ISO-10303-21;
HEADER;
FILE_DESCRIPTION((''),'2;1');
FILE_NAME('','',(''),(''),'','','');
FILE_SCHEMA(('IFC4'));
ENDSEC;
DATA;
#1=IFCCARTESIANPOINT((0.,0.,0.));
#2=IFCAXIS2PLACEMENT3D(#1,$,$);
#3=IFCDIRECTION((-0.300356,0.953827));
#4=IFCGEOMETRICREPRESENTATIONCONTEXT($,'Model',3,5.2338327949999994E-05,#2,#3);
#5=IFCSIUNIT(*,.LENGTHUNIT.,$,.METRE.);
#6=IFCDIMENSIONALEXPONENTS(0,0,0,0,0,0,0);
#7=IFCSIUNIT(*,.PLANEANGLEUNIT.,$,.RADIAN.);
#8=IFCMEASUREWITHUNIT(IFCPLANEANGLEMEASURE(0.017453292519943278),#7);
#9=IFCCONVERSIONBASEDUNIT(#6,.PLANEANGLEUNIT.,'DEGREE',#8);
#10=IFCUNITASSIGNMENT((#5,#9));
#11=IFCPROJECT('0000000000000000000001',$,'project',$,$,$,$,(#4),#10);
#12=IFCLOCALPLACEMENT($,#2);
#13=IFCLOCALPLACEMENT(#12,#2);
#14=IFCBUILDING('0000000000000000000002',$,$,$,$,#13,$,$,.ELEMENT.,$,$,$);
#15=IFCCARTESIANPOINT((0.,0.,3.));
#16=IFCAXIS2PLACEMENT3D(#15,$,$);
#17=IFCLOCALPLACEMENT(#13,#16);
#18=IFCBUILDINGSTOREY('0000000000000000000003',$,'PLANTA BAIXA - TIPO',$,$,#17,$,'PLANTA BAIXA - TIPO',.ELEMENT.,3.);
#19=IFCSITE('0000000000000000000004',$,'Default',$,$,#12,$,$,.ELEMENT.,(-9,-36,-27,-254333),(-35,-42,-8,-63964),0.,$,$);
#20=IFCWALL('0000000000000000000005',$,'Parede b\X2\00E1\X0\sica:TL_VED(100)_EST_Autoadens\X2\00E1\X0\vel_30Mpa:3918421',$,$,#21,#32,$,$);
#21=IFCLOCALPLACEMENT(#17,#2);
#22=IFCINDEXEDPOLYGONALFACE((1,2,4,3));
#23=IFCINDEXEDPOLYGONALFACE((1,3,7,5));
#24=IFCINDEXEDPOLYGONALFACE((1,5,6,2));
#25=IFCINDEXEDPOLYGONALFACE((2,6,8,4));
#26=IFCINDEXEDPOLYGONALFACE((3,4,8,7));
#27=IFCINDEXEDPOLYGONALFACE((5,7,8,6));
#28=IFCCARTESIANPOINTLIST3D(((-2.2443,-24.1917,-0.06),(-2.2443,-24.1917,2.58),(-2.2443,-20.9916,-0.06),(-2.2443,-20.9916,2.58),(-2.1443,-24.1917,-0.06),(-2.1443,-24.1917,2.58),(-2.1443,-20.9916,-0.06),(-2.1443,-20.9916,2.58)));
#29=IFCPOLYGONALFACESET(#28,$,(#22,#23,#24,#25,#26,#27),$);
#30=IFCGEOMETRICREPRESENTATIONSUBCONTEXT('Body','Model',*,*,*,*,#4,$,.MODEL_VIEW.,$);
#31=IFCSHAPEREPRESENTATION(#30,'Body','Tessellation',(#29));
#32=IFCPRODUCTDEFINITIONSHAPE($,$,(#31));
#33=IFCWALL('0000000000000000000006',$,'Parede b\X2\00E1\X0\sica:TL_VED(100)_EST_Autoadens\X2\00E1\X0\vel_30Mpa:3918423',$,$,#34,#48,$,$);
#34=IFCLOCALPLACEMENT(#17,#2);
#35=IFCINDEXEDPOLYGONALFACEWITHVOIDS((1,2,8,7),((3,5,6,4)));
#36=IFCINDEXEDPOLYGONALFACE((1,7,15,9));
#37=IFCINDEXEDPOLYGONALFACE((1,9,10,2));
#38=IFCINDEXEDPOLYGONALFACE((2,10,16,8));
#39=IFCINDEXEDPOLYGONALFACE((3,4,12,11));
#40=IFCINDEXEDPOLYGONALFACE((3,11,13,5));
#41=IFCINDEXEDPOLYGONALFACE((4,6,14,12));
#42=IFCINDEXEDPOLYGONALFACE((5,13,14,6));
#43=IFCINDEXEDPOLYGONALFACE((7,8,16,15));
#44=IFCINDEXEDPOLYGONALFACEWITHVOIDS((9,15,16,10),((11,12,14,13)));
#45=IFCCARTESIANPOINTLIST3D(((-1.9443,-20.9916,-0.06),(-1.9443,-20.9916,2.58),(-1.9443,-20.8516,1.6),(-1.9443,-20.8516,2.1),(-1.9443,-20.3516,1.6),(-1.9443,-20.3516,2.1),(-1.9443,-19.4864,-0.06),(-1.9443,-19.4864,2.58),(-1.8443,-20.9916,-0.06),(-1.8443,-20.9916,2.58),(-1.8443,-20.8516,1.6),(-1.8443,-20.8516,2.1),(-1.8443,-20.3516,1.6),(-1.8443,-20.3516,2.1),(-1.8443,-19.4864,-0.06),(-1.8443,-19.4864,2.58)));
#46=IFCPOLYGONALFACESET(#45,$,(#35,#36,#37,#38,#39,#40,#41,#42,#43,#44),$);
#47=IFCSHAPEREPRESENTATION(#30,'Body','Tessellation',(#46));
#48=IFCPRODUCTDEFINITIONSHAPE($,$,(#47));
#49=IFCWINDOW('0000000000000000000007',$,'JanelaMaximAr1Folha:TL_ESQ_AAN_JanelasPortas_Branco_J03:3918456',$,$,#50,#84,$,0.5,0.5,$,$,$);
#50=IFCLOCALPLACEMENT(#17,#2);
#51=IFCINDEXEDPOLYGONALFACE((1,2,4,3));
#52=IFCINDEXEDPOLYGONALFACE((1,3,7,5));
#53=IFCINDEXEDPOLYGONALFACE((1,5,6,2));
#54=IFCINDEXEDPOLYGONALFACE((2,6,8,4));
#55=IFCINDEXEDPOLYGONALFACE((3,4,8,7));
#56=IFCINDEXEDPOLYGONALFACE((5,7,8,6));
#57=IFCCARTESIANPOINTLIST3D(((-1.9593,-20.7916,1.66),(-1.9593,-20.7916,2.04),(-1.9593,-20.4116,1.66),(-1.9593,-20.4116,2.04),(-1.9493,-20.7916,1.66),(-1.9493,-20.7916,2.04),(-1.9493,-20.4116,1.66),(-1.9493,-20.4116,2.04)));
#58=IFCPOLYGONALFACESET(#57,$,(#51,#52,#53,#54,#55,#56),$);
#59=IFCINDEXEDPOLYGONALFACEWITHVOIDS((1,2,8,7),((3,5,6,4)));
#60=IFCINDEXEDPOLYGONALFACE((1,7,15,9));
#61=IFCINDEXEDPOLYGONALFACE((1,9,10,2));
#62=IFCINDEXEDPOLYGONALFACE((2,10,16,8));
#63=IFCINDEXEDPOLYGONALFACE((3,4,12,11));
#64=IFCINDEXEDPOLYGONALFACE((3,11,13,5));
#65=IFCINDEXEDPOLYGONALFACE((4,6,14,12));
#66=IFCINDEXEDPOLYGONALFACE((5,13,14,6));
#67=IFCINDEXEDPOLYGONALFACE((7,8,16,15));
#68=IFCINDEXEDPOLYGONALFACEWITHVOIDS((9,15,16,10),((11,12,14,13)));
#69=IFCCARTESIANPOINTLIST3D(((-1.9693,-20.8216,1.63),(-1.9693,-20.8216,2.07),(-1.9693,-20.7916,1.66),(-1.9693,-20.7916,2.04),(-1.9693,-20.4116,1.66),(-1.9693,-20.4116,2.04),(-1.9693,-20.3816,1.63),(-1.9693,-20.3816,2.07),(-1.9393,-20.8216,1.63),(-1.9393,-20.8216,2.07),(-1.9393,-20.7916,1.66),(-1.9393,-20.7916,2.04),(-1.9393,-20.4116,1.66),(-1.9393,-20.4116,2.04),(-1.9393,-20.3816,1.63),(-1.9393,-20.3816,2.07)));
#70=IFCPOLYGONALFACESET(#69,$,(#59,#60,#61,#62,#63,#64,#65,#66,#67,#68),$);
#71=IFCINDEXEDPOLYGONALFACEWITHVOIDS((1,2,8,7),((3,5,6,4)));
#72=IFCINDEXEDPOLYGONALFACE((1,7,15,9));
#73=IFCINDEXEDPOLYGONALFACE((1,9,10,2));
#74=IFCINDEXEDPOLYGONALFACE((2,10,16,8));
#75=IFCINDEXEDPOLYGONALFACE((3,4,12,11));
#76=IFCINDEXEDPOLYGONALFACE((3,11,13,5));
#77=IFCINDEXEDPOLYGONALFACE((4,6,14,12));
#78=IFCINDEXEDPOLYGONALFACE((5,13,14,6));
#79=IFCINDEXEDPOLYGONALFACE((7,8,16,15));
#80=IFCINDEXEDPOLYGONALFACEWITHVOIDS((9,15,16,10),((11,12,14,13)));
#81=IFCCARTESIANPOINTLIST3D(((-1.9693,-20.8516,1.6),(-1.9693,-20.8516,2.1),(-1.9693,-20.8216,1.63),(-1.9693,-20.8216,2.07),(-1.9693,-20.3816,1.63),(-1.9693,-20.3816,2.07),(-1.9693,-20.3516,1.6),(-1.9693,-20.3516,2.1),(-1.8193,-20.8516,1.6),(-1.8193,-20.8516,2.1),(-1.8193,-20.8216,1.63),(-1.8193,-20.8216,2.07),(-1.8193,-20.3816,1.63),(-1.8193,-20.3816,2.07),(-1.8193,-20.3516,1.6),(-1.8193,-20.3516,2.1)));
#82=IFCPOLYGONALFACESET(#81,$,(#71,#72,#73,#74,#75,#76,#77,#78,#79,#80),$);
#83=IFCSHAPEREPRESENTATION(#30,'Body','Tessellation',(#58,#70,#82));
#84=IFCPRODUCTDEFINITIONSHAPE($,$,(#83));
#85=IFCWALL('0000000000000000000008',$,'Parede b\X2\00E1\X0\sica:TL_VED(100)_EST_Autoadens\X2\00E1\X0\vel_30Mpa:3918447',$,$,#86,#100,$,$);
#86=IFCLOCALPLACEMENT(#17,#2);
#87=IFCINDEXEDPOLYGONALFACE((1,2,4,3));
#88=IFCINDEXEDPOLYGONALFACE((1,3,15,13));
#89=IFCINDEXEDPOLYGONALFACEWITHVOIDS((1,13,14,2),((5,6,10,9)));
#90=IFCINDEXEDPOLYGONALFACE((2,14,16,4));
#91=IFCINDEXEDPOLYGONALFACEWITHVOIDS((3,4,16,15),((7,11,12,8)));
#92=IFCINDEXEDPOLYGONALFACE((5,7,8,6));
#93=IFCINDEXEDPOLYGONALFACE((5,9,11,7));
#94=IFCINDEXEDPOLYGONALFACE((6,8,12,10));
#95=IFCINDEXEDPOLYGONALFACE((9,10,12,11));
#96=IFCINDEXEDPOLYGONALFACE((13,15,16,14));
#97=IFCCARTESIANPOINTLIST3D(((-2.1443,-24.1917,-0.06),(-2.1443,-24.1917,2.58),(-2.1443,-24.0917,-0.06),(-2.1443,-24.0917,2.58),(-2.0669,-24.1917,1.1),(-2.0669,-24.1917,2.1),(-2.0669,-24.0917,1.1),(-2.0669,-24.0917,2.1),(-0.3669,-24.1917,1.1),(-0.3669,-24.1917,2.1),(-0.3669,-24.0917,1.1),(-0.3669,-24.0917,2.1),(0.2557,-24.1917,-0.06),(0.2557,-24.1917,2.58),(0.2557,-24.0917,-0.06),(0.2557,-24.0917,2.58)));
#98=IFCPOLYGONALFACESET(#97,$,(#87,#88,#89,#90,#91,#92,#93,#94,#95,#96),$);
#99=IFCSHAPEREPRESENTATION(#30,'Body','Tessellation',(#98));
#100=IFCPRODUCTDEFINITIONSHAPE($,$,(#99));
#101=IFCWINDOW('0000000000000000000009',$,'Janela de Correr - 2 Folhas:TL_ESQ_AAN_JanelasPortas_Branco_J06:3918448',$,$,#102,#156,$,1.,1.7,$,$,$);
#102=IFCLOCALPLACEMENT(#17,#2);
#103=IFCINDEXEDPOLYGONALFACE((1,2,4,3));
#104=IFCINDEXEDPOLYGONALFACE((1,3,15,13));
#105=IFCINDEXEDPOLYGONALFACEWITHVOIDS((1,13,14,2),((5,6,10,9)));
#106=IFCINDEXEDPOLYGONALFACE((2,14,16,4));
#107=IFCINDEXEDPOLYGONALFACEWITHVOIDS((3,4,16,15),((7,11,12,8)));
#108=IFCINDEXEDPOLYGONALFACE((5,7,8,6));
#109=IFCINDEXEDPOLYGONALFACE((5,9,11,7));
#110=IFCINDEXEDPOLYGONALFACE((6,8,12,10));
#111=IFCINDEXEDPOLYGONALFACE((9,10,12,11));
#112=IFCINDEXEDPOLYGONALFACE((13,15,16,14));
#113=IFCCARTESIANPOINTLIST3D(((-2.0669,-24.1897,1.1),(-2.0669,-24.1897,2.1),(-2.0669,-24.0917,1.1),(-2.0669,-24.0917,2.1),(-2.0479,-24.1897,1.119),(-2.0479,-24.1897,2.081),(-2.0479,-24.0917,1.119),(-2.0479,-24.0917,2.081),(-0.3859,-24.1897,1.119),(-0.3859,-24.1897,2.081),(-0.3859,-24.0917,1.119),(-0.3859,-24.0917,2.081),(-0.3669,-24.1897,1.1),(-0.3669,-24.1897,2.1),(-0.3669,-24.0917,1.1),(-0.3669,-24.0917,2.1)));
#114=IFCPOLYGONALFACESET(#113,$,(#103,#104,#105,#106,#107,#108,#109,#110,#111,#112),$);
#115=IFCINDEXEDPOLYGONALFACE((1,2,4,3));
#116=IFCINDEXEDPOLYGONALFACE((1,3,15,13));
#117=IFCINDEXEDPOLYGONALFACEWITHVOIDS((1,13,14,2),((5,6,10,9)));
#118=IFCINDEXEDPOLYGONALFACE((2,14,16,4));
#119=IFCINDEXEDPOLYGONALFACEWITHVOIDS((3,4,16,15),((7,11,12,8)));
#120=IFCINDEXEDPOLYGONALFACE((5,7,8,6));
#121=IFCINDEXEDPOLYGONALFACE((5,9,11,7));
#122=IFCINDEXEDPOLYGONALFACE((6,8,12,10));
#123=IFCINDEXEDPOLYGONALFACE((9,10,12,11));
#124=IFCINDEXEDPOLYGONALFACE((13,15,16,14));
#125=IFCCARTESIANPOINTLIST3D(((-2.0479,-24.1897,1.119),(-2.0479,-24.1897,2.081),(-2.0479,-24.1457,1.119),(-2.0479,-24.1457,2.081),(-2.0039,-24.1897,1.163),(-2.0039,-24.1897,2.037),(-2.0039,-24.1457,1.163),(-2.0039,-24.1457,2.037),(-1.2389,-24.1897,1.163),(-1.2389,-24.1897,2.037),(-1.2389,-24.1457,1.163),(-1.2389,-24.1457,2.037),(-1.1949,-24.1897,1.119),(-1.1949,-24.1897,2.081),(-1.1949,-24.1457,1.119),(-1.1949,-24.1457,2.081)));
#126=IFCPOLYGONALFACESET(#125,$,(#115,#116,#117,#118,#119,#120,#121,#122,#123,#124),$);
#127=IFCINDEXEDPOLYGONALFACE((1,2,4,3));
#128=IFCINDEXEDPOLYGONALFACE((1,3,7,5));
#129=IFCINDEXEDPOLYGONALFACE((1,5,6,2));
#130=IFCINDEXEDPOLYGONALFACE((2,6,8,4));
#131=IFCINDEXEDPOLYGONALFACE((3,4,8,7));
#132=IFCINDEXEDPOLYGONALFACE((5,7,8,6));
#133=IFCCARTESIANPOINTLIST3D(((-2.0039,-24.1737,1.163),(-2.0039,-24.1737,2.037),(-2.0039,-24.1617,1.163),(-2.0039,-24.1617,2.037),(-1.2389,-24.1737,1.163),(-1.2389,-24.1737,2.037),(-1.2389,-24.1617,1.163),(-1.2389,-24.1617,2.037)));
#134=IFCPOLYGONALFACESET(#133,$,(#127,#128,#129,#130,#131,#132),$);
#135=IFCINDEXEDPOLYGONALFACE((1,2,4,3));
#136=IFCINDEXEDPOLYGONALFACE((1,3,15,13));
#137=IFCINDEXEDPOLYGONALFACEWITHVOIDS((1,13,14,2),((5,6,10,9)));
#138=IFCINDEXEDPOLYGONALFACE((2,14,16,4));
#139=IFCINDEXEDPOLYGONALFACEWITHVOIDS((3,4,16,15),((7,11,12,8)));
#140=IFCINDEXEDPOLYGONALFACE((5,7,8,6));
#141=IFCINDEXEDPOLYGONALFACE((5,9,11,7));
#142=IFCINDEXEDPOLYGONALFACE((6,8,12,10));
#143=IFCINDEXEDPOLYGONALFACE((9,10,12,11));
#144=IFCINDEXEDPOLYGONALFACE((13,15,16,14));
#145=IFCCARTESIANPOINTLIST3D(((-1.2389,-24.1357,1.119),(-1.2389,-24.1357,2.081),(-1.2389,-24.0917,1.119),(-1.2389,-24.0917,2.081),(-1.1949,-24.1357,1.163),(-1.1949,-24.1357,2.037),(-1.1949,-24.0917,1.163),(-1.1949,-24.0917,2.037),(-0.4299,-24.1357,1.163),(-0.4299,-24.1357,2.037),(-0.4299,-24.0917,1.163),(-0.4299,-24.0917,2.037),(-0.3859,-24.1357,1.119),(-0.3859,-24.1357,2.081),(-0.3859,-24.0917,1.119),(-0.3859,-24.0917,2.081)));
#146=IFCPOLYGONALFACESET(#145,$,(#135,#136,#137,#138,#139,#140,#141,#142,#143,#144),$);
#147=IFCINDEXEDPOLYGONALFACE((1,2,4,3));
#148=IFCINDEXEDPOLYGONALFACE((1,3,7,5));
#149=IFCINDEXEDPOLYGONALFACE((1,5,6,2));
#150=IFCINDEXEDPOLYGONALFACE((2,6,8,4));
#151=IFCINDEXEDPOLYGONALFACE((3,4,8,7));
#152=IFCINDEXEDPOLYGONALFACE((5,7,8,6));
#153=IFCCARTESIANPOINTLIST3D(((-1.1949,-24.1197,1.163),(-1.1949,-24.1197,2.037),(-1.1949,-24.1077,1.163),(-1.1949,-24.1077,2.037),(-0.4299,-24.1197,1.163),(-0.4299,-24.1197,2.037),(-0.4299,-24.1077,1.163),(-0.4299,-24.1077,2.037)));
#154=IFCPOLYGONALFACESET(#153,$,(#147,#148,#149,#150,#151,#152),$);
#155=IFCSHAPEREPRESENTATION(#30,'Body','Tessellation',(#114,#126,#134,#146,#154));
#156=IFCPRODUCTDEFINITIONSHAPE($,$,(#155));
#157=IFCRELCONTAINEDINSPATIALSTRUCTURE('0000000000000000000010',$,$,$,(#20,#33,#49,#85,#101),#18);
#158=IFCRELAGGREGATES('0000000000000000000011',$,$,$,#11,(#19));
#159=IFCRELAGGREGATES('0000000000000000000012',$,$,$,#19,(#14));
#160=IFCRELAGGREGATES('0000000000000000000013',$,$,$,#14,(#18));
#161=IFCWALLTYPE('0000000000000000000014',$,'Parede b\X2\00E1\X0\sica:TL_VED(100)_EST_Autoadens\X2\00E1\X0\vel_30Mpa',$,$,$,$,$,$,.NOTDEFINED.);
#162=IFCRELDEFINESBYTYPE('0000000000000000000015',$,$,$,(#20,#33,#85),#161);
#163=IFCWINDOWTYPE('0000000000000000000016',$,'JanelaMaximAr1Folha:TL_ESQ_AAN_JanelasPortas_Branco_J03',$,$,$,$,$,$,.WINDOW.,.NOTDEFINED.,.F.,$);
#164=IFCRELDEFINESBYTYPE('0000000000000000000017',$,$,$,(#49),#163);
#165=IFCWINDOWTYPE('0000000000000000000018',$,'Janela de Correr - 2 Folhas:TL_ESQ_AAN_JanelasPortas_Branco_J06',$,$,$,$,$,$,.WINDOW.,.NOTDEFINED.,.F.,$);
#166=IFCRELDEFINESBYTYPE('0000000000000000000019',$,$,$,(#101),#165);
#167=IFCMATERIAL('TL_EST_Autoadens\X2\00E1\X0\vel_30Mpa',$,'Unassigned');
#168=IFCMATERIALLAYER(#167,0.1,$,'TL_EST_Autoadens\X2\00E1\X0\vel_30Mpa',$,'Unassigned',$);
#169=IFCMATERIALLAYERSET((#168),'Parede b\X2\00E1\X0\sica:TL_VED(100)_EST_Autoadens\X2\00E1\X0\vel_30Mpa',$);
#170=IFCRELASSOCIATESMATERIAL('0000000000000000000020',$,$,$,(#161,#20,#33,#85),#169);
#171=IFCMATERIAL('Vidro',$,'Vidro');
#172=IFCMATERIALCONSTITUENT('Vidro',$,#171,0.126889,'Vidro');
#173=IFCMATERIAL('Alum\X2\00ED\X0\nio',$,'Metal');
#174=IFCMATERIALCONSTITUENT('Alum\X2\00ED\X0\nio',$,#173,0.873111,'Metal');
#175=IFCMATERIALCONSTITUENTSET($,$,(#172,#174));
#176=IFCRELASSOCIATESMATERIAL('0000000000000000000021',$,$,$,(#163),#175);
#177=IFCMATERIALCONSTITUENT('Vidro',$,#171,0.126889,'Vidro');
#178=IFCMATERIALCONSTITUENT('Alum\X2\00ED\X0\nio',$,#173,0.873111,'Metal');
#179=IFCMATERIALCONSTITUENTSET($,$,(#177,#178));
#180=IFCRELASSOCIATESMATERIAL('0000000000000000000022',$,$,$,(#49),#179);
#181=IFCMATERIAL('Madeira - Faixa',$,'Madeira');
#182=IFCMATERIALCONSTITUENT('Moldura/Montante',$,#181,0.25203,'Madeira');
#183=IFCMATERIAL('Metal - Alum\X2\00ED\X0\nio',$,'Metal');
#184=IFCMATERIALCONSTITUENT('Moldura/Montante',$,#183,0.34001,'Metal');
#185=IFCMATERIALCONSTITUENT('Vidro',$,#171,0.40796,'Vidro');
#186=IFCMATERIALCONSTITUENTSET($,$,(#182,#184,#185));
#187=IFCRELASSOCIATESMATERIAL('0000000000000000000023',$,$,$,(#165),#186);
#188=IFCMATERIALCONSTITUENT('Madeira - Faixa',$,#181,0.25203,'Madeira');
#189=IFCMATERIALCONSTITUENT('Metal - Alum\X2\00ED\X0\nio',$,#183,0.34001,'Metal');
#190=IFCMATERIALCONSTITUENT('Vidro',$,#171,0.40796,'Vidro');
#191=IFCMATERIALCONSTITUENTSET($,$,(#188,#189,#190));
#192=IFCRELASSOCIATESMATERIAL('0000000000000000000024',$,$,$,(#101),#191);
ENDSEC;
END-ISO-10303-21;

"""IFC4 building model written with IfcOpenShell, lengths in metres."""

from ifc_helpers import new_model, entity, si_unit, converted_unit, direction, frame, frame_2d, origin, origin_2d_with_axis, place, context, subcontext, project, spatial, polyline, rectangle, outline, extrude, source, transform, mapped, material, layer, layer_set, layer_usage, constituent, constituent_set, type_object, type_shapes, element, fill, save


model = new_model("IFC4")

# Units and contexts
model_context = context("Model", 3, precision=5.2338327949999994e-05, world=origin(), true_north=direction((-0.300356, 0.953827)))
body_context = subcontext(model_context, "Body", "Model", "MODEL_VIEW")
ifc_project = project(units=[si_unit("LENGTHUNIT", "METRE"), converted_unit("PLANEANGLEUNIT", "DEGREE", entity("IfcPlaneAngleMeasure", 0.017453292519943278), si_unit("PLANEANGLEUNIT", "RADIAN"), dimensions=[0, 0, 0, 0, 0, 0, 0])], contexts=[model_context])

# Site, building, storey
site_placement = place(None, origin())
site = spatial("IfcSite", under=ifc_project, at=site_placement, Name="Default", CompositionType="ELEMENT", RefLatitude=(-9, -36, -27, -254333), RefLongitude=(-35, -42, -8, -63964), RefElevation=0.0)
building_placement = place(site_placement, origin())
building = spatial("IfcBuilding", under=site, at=building_placement, CompositionType="ELEMENT")
storey_placement = place(building_placement, frame((0.0, 0.0, 3.0)))
storey = spatial("IfcBuildingStorey", under=building, at=storey_placement, Name="PLANTA BAIXA - TIPO", LongName="PLANTA BAIXA - TIPO", CompositionType="ELEMENT", Elevation=3.0)

# Wall
ifc_material_1 = material(Name="TL_EST_Autoadensável_30Mpa", Category="Unassigned")
ifc_layer_1 = layer(ifc_material_1, 0.1, Name="TL_EST_Autoadensável_30Mpa", Category="Unassigned")
ifc_layer_set_1 = layer_set([ifc_layer_1], Name="Parede básica:TL_VED(100)_EST_Autoadensável_30Mpa")
ifc_layer_usage_1 = layer_usage(ifc_layer_set_1, "AXIS2", "POSITIVE", -0.05)
wall_type_1 = type_object("IfcWallType", Name="Parede básica:TL_VED(100)_EST_Autoadensável_30Mpa", PredefinedType="NOTDEFINED", material=ifc_layer_set_1)
wall_1_placement = place(storey_placement, frame((-2.1943, -24.1917, -0.06), z_axis=(0.0, 0.0, 1.0), x_axis=(0.0, 1.0, 0.0)))
element("IfcWall", 1, at=wall_1_placement, inside=storey, type_object=wall_type_1, material=ifc_layer_usage_1, Name="Parede básica:TL_VED(100)_EST_Autoadensável_30Mpa:3918421", context=body_context, shape_type="SweptSolid", body=[
    extrude(rectangle(XDim=3.2001, YDim=0.1, at=frame_2d((1.6001, 0.0), x_axis=(-1.0, 0.0))), origin(), (0.0, 0.0, 1.0), 2.64),
])

# Walls, openings, windows
ifc_layer_usage_2 = layer_usage(ifc_layer_set_1, "AXIS2", "POSITIVE", -0.05)
wall_2_placement = place(storey_placement, frame((-1.8943, -19.4864, -0.06), z_axis=(0.0, 0.0, 1.0), x_axis=(0.0, -1.0, 0.0)))
wall_2 = element("IfcWall", 2, at=wall_2_placement, inside=storey, type_object=wall_type_1, material=ifc_layer_usage_2, Name="Parede básica:TL_VED(100)_EST_Autoadensável_30Mpa:3918423", context=body_context, shape_type="SweptSolid", body=[
    extrude(rectangle(XDim=1.5052, YDim=0.1, at=frame_2d((0.7526, 0.0), x_axis=(-1.0, 0.0))), origin(), (0.0, 0.0, 1.0), 2.64),
])
opening_1_placement = place(wall_2_placement, frame((0.8652, -0.05, 1.66)))
opening_1 = element("IfcOpeningElement", 3, at=opening_1_placement, cuts=wall_2, PredefinedType="OPENING", context=body_context, shape_type="SweptSolid", body=[
    extrude(rectangle(XDim=0.5, YDim=0.5, at=frame_2d((0.25, 0.25), x_axis=(1.0, 0.0))), frame((0.0, 0.0, 0.0), z_axis=(0.0, 1.0, 0.0), x_axis=(0.0, 0.0, 1.0)), (0.0, 0.0, 1.0), 0.1),
])
ifc_material_2 = material(Name="Vidro", Category="Vidro")
ifc_constituent_1 = constituent(ifc_material_2, Name="Vidro", Category="Vidro", fraction=0.126889)
ifc_material_3 = material(Name="Alumínio", Category="Metal")
ifc_constituent_2 = constituent(ifc_material_3, Name="Alumínio", Category="Metal", fraction=0.873111)
ifc_constituent_set_1 = constituent_set(constituents=[ifc_constituent_1, ifc_constituent_2])
ifc_constituent_3 = constituent(ifc_material_2, Name="Vidro", Category="Vidro", fraction=0.126889)
ifc_constituent_4 = constituent(ifc_material_3, Name="Alumínio", Category="Metal", fraction=0.873111)
ifc_constituent_set_2 = constituent_set(constituents=[ifc_constituent_3, ifc_constituent_4])
window_type_1 = type_object("IfcWindowType", Name="JanelaMaximAr1Folha:TL_ESQ_AAN_JanelasPortas_Branco_J03", ParameterTakesPrecedence=False, PartitioningType="NOTDEFINED", PredefinedType="WINDOW", material=ifc_constituent_set_2)
shared_shape_1 = source(origin(), body_context, "Body", "SweptSolid", [
    extrude(rectangle(XDim=0.38, YDim=0.01, at=frame_2d((0.0, 0.0), x_axis=(1.0, 0.0))), frame((0.25, -0.01, 0.06)), (0.0, 0.0, 1.0), 0.38),
    extrude(outline(polyline([(-0.22, -0.22), (0.22, -0.22), (0.22, 0.22), (-0.22, 0.22), (-0.22, -0.22)]), holes=[polyline([(0.19, 0.19), (0.19, -0.19), (-0.19, -0.19), (-0.19, 0.19), (0.19, 0.19)])]), frame((0.25, 0.005, 0.25), z_axis=(0.0, -1.0, 0.0), x_axis=(0.0, 0.0, -1.0)), (0.0, 0.0, 1.0), 0.03),
    extrude(outline(polyline([(-0.25, -0.25), (0.25, -0.25), (0.25, 0.25), (-0.25, 0.25), (-0.25, -0.25)]), holes=[polyline([(-0.22, -0.22), (-0.22, 0.22), (0.22, 0.22), (0.22, -0.22), (-0.22, -0.22)])]), frame((0.25, 0.125, 0.25), z_axis=(0.0, -1.0, 0.0), x_axis=(0.0, 0.0, -1.0)), (0.0, 0.0, 1.0), 0.15),
])
type_shapes(window_type_1, [shared_shape_1])
window_1_placement = place(opening_1_placement, origin())
window_1 = element("IfcWindow", 4, at=window_1_placement, inside=storey, type_object=window_type_1, material=ifc_constituent_set_1, Name="JanelaMaximAr1Folha:TL_ESQ_AAN_JanelasPortas_Branco_J03:3918456", OverallHeight=0.5, OverallWidth=0.5, context=body_context, shape_type="MappedRepresentation", body=[
    mapped(shared_shape_1, transform((0.0, 0.0, 0.0), scale=1.0)),
])
fill(opening_1, window_1)
ifc_layer_usage_3 = layer_usage(ifc_layer_set_1, "AXIS2", "POSITIVE", -0.05)
wall_3_placement = place(storey_placement, frame((-2.1443, -24.1417, -0.06)))
wall_3 = element("IfcWall", 5, at=wall_3_placement, inside=storey, type_object=wall_type_1, material=ifc_layer_usage_3, Name="Parede básica:TL_VED(100)_EST_Autoadensável_30Mpa:3918447", context=body_context, shape_type="SweptSolid", body=[
    extrude(rectangle(XDim=2.4, YDim=0.1, at=frame_2d((1.2, 0.0), x_axis=(-1.0, 0.0))), origin(), (0.0, 0.0, 1.0), 2.64),
])
opening_2_placement = place(wall_3_placement, frame((1.7774, 0.05, 1.16)))
opening_2 = element("IfcOpeningElement", 6, at=opening_2_placement, cuts=wall_3, PredefinedType="OPENING", context=body_context, shape_type="SweptSolid", body=[
    extrude(rectangle(XDim=1.0, YDim=1.7, at=frame_2d((0.5, 0.85), x_axis=(-1.0, 0.0))), frame((0.0, 0.0, 0.0), z_axis=(0.0, -1.0, 0.0), x_axis=(0.0, 0.0, 1.0)), (0.0, 0.0, 1.0), 0.1),
])
ifc_material_4 = material(Name="Madeira - Faixa", Category="Madeira")
ifc_constituent_5 = constituent(ifc_material_4, Name="Madeira - Faixa", Category="Madeira", fraction=0.25203)
ifc_material_5 = material(Name="Metal - Alumínio", Category="Metal")
ifc_constituent_6 = constituent(ifc_material_5, Name="Metal - Alumínio", Category="Metal", fraction=0.34001)
ifc_constituent_7 = constituent(ifc_material_2, Name="Vidro", Category="Vidro", fraction=0.40796)
ifc_constituent_set_3 = constituent_set(constituents=[ifc_constituent_5, ifc_constituent_6, ifc_constituent_7])
ifc_constituent_8 = constituent(ifc_material_4, Name="Moldura/Montante", Category="Madeira", fraction=0.25203)
ifc_constituent_9 = constituent(ifc_material_5, Name="Moldura/Montante", Category="Metal", fraction=0.34001)
ifc_constituent_10 = constituent(ifc_material_2, Name="Vidro", Category="Vidro", fraction=0.40796)
ifc_constituent_set_4 = constituent_set(constituents=[ifc_constituent_8, ifc_constituent_9, ifc_constituent_10])
window_type_2 = type_object("IfcWindowType", Name="Janela de Correr - 2 Folhas:TL_ESQ_AAN_JanelasPortas_Branco_J06", ParameterTakesPrecedence=False, PartitioningType="NOTDEFINED", PredefinedType="WINDOW", material=ifc_constituent_set_4)
shared_shape_2 = source(origin(), body_context, "Body", "SweptSolid", [
    extrude(outline(polyline([(-0.85, -0.5), (0.85, -0.5), (0.85, 0.5), (-0.85, 0.5), (-0.85, -0.5)]), holes=[polyline([(-0.831, -0.481), (-0.831, 0.481), (0.831, 0.481), (0.831, -0.481), (-0.831, -0.481)])]), frame((0.85, 0.0, 0.5), z_axis=(0.0, 1.0, 0.0), x_axis=(1.0, 0.0, 0.0)), (0.0, 0.0, 1.0), 0.098),
    extrude(outline(polyline([(-0.4265, -0.481), (0.4265, -0.481), (0.4265, 0.481), (-0.4265, 0.481), (-0.4265, -0.481)]), holes=[polyline([(-0.3825, -0.437), (-0.3825, 0.437), (0.3825, 0.437), (0.3825, -0.437), (-0.3825, -0.437)])]), frame((1.2545, 0.054, 0.5), z_axis=(0.0, 1.0, 0.0), x_axis=(1.0, 0.0, 0.0)), (0.0, 0.0, 1.0), 0.044),
    extrude(rectangle(XDim=0.012, YDim=0.765, at=origin_2d_with_axis()), frame((1.2545, 0.076, 0.063), z_axis=(0.0, 0.0, 1.0), x_axis=(0.0, -1.0, 0.0)), (0.0, 0.0, 1.0), 0.874),
    extrude(outline(polyline([(-0.481, -0.4265), (0.481, -0.4265), (0.481, 0.4265), (-0.481, 0.4265), (-0.481, -0.4265)]), holes=[polyline([(-0.437, -0.3825), (-0.437, 0.3825), (0.437, 0.3825), (0.437, -0.3825), (-0.437, -0.3825)])]), frame((0.4455, 0.0, 0.5), z_axis=(0.0, 1.0, 0.0), x_axis=(0.0, 0.0, -1.0)), (0.0, 0.0, 1.0), 0.044),
    extrude(rectangle(XDim=0.012, YDim=0.765, at=origin_2d_with_axis()), frame((0.4455, 0.022, 0.063), z_axis=(0.0, 0.0, 1.0), x_axis=(0.0, -1.0, 0.0)), (0.0, 0.0, 1.0), 0.874),
])
type_shapes(window_type_2, [shared_shape_2])
window_2_placement = place(opening_2_placement, frame((0.0, 0.0, 0.0), z_axis=(0.0, 0.0, 1.0), x_axis=(-1.0, 0.0, 0.0)))
window_2 = element("IfcWindow", 7, at=window_2_placement, inside=storey, type_object=window_type_2, material=ifc_constituent_set_3, Name="Janela de Correr - 2 Folhas:TL_ESQ_AAN_JanelasPortas_Branco_J06:3918448", OverallHeight=1.0, OverallWidth=1.7, context=body_context, shape_type="MappedRepresentation", body=[
    mapped(shared_shape_2, transform((0.0, 0.0, 0.0), scale=1.0)),
])
fill(opening_2, window_2)

save(model, "model.ifc")
